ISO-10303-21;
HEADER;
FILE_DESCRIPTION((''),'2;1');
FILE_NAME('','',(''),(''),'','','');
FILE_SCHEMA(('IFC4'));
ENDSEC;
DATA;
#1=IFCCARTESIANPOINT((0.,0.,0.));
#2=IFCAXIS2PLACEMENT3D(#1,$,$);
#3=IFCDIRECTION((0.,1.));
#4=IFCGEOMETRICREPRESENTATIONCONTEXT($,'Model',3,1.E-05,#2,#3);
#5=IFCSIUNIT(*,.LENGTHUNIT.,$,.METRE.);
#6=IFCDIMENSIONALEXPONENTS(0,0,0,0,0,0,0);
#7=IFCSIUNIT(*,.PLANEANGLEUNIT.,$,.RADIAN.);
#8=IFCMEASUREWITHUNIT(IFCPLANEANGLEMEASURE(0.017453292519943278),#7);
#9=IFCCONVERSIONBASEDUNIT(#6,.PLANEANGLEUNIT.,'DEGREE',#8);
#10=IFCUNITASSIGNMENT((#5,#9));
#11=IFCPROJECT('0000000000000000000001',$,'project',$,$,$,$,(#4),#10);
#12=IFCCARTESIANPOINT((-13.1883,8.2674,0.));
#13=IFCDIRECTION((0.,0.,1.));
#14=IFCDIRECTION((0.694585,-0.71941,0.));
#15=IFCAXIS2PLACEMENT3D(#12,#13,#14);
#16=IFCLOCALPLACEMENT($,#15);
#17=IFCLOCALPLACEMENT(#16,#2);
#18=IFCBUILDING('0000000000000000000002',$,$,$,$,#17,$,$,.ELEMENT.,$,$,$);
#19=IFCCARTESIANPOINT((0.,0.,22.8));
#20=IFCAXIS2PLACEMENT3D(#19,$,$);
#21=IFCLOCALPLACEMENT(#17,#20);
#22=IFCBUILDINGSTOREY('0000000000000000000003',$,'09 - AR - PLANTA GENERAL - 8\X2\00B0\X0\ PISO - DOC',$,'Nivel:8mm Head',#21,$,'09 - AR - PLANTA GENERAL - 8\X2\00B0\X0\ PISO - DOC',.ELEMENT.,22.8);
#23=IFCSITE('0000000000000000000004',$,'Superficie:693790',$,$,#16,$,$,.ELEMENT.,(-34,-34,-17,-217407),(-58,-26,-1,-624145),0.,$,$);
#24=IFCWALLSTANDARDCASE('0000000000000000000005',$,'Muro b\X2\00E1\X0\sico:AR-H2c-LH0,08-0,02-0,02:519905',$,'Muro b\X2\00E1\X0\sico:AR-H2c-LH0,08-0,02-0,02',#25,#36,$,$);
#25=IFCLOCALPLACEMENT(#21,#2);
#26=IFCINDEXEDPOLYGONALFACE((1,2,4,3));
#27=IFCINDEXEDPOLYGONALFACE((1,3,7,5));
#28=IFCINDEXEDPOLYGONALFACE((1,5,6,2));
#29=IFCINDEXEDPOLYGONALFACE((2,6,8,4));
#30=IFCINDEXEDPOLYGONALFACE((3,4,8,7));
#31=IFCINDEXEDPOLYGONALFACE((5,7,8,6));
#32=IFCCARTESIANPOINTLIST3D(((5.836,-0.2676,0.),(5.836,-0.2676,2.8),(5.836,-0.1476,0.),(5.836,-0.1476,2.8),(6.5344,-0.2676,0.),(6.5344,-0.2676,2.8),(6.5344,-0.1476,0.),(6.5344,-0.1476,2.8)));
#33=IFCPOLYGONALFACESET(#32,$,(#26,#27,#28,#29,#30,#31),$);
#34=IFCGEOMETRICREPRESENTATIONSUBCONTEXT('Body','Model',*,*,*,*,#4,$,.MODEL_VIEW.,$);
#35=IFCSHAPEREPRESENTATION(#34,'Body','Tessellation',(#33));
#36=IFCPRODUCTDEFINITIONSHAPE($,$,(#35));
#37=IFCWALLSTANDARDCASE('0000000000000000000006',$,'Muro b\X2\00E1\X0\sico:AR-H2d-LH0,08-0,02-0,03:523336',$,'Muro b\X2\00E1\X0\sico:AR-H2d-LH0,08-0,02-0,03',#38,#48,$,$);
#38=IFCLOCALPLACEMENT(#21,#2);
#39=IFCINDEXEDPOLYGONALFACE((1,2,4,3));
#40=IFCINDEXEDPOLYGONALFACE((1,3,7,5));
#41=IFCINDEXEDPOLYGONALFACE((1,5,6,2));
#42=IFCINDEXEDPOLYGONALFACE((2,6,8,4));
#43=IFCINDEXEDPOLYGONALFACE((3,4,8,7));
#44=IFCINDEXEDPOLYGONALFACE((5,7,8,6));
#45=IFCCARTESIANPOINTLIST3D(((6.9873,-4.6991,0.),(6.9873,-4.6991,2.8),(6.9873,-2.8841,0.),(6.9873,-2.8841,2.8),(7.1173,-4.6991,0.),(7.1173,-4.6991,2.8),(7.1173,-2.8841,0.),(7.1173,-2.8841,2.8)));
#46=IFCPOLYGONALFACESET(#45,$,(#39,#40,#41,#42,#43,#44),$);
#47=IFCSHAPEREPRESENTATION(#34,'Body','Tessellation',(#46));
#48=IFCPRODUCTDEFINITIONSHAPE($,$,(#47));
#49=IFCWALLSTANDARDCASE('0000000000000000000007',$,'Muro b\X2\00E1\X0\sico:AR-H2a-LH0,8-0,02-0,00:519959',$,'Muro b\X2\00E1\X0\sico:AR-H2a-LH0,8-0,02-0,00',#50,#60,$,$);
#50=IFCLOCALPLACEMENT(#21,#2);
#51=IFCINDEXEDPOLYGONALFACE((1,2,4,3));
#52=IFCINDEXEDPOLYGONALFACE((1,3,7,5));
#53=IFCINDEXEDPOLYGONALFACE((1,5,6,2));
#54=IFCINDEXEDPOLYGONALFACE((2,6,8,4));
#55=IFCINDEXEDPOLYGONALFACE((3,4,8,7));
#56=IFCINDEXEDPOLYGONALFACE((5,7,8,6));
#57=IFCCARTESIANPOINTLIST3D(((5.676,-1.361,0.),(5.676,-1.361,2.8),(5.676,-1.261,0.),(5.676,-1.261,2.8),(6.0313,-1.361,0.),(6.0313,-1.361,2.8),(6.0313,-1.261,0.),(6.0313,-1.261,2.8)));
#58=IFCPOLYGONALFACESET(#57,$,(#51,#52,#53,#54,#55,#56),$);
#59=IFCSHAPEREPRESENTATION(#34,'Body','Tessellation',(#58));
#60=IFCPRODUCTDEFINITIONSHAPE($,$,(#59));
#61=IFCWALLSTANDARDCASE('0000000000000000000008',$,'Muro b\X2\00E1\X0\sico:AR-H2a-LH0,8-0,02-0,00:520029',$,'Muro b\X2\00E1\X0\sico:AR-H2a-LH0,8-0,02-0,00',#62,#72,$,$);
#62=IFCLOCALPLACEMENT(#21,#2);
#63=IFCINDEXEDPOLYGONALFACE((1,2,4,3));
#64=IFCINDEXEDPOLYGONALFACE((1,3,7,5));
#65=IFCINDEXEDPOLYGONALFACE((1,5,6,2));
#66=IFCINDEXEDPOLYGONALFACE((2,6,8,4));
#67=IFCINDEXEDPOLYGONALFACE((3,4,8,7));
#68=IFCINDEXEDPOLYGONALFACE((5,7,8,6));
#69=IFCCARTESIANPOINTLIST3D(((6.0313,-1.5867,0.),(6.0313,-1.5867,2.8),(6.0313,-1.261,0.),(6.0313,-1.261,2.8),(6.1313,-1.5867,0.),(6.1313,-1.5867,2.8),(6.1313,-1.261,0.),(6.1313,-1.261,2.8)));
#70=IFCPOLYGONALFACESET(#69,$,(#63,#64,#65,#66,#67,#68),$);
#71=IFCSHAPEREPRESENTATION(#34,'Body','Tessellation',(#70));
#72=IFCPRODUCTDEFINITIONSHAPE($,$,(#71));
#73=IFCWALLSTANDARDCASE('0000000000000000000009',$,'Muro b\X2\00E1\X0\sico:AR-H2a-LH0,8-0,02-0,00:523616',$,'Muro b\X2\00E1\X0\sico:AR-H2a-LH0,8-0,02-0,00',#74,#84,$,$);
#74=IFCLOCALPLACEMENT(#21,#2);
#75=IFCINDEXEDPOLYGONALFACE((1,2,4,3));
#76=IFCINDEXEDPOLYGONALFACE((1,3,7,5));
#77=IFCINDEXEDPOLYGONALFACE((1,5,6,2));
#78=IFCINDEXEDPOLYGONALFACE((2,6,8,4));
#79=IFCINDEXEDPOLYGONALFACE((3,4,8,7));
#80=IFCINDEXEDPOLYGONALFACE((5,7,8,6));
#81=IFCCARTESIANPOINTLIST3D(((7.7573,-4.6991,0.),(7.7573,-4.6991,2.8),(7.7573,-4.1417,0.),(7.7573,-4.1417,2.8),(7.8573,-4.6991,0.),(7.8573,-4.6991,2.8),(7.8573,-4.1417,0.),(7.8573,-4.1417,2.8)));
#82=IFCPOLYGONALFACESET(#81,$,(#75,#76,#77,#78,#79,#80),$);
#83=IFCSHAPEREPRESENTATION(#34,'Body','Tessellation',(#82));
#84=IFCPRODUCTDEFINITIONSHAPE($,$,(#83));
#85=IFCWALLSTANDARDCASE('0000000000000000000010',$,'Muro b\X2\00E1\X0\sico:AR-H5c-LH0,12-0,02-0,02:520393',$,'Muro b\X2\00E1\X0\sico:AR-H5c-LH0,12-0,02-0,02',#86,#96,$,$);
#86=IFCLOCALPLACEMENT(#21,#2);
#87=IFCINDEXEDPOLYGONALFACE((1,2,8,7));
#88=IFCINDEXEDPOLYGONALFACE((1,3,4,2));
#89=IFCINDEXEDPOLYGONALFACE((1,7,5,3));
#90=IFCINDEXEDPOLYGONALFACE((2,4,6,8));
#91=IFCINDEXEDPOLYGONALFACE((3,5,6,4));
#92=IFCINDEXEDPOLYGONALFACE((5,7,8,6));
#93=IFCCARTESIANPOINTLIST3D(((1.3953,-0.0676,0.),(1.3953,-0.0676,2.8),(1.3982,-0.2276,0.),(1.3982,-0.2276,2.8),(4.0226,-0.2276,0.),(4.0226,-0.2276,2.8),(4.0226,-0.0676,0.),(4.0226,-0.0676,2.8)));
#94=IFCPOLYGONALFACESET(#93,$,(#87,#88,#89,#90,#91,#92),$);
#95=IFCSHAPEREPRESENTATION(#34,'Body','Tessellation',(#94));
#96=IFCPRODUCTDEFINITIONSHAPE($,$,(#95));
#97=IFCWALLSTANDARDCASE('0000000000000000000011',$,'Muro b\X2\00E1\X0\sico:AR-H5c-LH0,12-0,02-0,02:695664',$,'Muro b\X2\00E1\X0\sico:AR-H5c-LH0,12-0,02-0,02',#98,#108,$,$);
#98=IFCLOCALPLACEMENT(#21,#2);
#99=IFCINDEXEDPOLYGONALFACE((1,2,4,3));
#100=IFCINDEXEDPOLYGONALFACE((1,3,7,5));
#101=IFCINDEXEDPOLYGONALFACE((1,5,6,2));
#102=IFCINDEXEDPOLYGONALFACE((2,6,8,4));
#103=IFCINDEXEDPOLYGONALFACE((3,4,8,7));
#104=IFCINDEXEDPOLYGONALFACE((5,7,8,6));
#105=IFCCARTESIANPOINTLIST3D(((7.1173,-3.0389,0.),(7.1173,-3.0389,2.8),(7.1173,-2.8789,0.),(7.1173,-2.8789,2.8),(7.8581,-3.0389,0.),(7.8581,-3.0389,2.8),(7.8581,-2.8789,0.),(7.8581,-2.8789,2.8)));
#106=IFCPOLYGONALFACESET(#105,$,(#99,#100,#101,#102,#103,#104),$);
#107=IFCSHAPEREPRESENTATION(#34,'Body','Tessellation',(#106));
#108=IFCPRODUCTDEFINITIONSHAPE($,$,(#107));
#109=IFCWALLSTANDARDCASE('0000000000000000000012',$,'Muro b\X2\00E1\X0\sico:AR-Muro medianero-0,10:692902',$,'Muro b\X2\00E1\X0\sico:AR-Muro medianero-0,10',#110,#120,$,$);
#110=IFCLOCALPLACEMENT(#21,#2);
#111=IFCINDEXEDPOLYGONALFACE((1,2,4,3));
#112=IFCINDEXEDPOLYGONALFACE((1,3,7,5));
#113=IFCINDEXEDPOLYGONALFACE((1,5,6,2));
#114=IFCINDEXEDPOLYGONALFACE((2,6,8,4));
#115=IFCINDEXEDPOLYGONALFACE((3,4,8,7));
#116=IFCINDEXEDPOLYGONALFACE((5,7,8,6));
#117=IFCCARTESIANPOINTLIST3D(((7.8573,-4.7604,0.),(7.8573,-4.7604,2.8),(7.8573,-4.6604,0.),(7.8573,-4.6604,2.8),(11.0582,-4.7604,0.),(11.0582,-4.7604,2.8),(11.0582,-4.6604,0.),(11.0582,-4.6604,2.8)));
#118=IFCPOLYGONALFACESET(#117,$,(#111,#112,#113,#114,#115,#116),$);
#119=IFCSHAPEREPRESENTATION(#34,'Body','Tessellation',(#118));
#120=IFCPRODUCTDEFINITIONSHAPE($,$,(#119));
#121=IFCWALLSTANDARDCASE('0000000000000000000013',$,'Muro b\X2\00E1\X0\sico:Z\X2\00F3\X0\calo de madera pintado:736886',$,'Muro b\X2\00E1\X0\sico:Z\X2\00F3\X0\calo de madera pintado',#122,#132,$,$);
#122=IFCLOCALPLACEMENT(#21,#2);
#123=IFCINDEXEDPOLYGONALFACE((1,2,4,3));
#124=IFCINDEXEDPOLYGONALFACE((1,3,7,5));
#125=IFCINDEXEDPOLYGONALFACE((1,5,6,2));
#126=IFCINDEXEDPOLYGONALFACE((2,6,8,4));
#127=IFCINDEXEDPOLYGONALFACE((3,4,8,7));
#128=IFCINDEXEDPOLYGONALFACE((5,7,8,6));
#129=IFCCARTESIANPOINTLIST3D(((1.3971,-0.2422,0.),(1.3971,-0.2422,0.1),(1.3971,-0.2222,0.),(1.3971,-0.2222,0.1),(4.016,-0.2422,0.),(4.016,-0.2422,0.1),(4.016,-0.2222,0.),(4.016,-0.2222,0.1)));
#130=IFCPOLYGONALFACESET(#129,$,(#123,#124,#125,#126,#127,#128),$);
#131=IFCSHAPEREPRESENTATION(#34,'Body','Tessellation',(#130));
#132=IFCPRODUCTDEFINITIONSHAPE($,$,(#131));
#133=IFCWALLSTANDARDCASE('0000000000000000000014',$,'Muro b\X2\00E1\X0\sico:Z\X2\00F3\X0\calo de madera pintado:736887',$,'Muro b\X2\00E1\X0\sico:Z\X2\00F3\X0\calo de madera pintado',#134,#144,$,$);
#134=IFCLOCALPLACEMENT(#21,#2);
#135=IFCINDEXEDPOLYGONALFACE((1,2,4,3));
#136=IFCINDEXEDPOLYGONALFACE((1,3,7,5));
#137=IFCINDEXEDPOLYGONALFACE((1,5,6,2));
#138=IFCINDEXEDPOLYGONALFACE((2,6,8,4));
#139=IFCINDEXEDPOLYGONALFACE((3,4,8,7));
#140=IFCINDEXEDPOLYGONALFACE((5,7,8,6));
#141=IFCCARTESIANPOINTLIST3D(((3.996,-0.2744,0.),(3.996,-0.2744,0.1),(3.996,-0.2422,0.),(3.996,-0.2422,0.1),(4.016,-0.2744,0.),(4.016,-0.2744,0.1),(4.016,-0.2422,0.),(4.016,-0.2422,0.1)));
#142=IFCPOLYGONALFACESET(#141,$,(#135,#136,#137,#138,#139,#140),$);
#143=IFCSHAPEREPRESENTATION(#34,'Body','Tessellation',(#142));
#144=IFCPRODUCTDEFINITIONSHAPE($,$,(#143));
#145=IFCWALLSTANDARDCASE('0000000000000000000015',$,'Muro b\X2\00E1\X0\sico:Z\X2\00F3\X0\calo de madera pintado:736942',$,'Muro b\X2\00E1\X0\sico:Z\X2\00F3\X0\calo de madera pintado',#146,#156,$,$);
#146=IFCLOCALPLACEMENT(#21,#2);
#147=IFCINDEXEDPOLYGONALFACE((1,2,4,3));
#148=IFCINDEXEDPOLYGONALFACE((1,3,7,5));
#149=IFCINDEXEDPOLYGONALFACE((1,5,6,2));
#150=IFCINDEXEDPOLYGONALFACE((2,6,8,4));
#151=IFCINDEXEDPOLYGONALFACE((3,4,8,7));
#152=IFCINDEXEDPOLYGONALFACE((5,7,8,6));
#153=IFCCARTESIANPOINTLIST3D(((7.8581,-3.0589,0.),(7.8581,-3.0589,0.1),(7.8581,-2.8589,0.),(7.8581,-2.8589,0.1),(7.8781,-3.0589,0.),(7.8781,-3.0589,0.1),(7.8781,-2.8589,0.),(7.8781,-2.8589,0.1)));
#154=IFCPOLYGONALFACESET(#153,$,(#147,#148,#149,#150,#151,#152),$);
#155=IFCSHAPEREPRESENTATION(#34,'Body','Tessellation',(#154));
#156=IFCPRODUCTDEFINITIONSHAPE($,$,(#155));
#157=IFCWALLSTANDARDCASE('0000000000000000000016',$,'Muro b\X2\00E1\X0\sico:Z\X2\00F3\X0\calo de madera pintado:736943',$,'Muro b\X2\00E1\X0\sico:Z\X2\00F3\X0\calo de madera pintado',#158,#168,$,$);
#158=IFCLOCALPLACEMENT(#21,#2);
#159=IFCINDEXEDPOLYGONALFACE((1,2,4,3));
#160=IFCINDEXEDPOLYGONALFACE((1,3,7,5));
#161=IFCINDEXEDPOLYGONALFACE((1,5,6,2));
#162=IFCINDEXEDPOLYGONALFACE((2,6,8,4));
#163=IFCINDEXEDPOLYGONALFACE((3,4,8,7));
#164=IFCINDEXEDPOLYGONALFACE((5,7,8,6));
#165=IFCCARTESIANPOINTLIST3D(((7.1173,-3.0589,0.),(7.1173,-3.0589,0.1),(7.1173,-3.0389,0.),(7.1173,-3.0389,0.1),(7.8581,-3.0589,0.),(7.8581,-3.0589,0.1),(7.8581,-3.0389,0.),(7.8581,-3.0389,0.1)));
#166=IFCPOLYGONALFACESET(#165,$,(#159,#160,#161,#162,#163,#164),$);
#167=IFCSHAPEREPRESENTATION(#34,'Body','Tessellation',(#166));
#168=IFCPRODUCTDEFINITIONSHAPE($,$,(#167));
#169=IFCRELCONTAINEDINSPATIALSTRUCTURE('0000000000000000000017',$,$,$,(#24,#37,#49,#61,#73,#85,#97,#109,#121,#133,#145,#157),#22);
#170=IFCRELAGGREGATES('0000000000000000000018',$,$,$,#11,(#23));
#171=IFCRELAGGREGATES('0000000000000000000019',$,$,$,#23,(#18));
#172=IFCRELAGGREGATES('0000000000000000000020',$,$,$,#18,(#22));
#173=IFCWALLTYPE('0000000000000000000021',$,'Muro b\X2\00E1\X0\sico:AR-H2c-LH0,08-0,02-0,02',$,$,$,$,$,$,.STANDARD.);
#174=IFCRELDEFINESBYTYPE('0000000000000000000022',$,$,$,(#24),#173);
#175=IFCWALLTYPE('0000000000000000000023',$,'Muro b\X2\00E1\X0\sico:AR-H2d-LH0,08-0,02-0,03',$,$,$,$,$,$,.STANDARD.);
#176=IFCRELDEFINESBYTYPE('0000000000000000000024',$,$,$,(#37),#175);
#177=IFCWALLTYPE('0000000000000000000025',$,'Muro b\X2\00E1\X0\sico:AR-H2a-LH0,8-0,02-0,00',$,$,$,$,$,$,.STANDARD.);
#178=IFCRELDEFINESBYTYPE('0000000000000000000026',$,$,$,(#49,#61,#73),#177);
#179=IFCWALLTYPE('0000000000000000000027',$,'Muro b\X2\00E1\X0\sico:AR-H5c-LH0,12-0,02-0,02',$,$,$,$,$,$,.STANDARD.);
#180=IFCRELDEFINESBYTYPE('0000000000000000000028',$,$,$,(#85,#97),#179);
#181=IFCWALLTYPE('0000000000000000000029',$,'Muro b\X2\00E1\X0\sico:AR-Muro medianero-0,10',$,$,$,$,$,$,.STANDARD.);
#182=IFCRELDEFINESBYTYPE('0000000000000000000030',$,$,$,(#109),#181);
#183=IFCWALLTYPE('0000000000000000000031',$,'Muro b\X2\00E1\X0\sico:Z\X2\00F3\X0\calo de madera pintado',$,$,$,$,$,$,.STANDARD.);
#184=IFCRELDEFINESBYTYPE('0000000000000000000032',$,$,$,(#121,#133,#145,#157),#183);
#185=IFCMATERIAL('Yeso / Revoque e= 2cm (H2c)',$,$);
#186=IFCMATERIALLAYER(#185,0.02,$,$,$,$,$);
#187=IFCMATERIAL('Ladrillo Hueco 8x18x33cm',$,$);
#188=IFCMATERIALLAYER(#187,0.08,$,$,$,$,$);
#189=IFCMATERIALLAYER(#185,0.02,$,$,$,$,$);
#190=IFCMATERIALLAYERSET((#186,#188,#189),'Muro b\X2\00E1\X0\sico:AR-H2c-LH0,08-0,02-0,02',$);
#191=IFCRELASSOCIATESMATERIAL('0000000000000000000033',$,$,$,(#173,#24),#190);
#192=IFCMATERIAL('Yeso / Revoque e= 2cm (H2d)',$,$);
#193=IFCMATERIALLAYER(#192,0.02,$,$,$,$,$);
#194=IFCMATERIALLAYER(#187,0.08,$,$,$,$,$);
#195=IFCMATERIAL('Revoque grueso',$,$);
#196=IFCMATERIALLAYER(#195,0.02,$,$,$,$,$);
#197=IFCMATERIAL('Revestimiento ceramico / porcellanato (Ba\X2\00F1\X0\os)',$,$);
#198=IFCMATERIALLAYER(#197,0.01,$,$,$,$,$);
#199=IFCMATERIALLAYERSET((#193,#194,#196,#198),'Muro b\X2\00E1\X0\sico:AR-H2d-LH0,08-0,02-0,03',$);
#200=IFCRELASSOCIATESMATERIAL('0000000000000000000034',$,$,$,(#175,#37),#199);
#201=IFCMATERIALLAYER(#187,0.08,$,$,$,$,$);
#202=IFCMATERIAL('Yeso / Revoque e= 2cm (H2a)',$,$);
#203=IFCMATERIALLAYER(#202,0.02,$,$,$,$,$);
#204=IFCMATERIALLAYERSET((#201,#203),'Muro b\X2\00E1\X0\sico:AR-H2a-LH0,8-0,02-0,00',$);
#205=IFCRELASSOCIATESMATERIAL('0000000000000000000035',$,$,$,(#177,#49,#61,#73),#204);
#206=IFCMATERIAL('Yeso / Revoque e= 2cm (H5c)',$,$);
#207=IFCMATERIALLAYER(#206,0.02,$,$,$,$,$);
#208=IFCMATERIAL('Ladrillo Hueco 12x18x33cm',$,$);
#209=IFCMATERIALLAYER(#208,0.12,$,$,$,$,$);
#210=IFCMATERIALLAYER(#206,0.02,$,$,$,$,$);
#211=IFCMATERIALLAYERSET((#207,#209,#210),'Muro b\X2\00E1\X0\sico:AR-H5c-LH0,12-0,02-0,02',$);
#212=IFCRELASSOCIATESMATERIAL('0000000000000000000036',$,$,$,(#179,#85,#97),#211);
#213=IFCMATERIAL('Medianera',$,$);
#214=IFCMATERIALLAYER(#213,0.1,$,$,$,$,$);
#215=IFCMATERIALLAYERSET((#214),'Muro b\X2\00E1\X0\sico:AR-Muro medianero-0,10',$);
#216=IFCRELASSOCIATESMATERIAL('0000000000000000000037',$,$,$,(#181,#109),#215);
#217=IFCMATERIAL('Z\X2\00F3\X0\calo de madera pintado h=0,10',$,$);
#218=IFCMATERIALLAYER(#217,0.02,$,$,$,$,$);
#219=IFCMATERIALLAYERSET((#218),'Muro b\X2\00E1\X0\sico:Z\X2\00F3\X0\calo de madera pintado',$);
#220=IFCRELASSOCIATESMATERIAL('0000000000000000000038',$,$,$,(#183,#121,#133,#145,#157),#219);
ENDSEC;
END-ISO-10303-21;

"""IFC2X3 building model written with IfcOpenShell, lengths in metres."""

from ifc_helpers import new_model, entity, si_unit, converted_unit, direction, frame, frame_2d, origin, place, context, subcontext, project, spatial, polyline, rectangle, outline, extrude, material, layer, layer_set, layer_usage, type_object, element, save


model = new_model("IFC2X3")

# Units and contexts
model_context = context("Model", 3, precision=1e-05, world=origin(), true_north=direction((0.0, 1.0)))
body_context = subcontext(model_context, "Body", "Model", "MODEL_VIEW")
ifc_project = project(units=[si_unit("LENGTHUNIT", "METRE"), converted_unit("PLANEANGLEUNIT", "DEGREE", entity("IfcPlaneAngleMeasure", 0.017453292519943278), si_unit("PLANEANGLEUNIT", "RADIAN"), dimensions=[0, 0, 0, 0, 0, 0, 0])], contexts=[model_context])

# Site, building, storey
site_placement = place(None, frame((-13.1883, 8.2674, 0.0), z_axis=(0.0, 0.0, 1.0), x_axis=(0.694585, -0.71941, 0.0)))
site = spatial("IfcSite", under=ifc_project, at=site_placement, Name="Superficie:693790", CompositionType="ELEMENT", RefLatitude=(-34, -34, -17, -217407), RefLongitude=(-58, -26, -1, -624145), RefElevation=0.0)
building_placement = place(site_placement, origin())
building = spatial("IfcBuilding", under=site, at=building_placement, CompositionType="ELEMENT")
storey_placement = place(building_placement, frame((0.0, 0.0, 22.8)))
storey = spatial("IfcBuildingStorey", under=building, at=storey_placement, Name="09 - AR - PLANTA GENERAL - 8° PISO - DOC", ObjectType="Nivel:8mm Head", LongName="09 - AR - PLANTA GENERAL - 8° PISO - DOC", CompositionType="ELEMENT", Elevation=22.8)

# Walls
ifc_material_1 = material(Name="Yeso / Revoque e= 2cm (H2c)")
ifc_layer_1 = layer(ifc_material_1, 0.02)
ifc_material_2 = material(Name="Ladrillo Hueco 8x18x33cm")
ifc_layer_2 = layer(ifc_material_2, 0.08)
ifc_layer_3 = layer(ifc_material_1, 0.02)
ifc_layer_set_1 = layer_set([ifc_layer_1, ifc_layer_2, ifc_layer_3], Name="Muro básico:AR-H2c-LH0,08-0,02-0,02")
ifc_layer_usage_1 = layer_usage(ifc_layer_set_1, "AXIS2", "NEGATIVE", 0.06)
wall_type_1 = type_object("IfcWallType", Name="Muro básico:AR-H2c-LH0,08-0,02-0,02", PredefinedType="STANDARD", material=ifc_layer_set_1)
wall_1_placement = place(storey_placement, frame((5.836, -0.2076, 0.0)))
element("IfcWallStandardCase", 1, at=wall_1_placement, inside=storey, type_object=wall_type_1, material=ifc_layer_usage_1, Name="Muro básico:AR-H2c-LH0,08-0,02-0,02:519905", ObjectType="Muro básico:AR-H2c-LH0,08-0,02-0,02", context=body_context, shape_type="SweptSolid", body=[
    extrude(rectangle(XDim=0.6984, YDim=0.12, at=frame_2d((0.3492, 0.0), x_axis=(-1.0, 0.0))), origin(), (0.0, 0.0, 1.0), 2.8),
])
ifc_material_3 = material(Name="Yeso / Revoque e= 2cm (H2d)")
ifc_layer_4 = layer(ifc_material_3, 0.02)
ifc_layer_5 = layer(ifc_material_2, 0.08)
ifc_material_4 = material(Name="Revoque grueso")
ifc_layer_6 = layer(ifc_material_4, 0.02)
ifc_material_5 = material(Name="Revestimiento ceramico / porcellanato (Baños)")
ifc_layer_7 = layer(ifc_material_5, 0.01)
ifc_layer_set_2 = layer_set([ifc_layer_4, ifc_layer_5, ifc_layer_6, ifc_layer_7], Name="Muro básico:AR-H2d-LH0,08-0,02-0,03")
ifc_layer_usage_2 = layer_usage(ifc_layer_set_2, "AXIS2", "NEGATIVE", 0.065)
wall_type_2 = type_object("IfcWallType", Name="Muro básico:AR-H2d-LH0,08-0,02-0,03", PredefinedType="STANDARD", material=ifc_layer_set_2)
wall_2_placement = place(storey_placement, frame((7.0523, -2.8841, 0.0), z_axis=(0.0, 0.0, 1.0), x_axis=(0.0, -1.0, 0.0)))
element("IfcWallStandardCase", 2, at=wall_2_placement, inside=storey, type_object=wall_type_2, material=ifc_layer_usage_2, Name="Muro básico:AR-H2d-LH0,08-0,02-0,03:523336", ObjectType="Muro básico:AR-H2d-LH0,08-0,02-0,03", context=body_context, shape_type="SweptSolid", body=[
    extrude(rectangle(XDim=1.815, YDim=0.13, at=frame_2d((0.9075, 0.0), x_axis=(-1.0, 0.0))), origin(), (0.0, 0.0, 1.0), 2.8),
])
ifc_layer_8 = layer(ifc_material_2, 0.08)
ifc_material_6 = material(Name="Yeso / Revoque e= 2cm (H2a)")
ifc_layer_9 = layer(ifc_material_6, 0.02)
ifc_layer_set_3 = layer_set([ifc_layer_8, ifc_layer_9], Name="Muro básico:AR-H2a-LH0,8-0,02-0,00")
ifc_layer_usage_3 = layer_usage(ifc_layer_set_3, "AXIS2", "POSITIVE", -0.05)
wall_type_3 = type_object("IfcWallType", Name="Muro básico:AR-H2a-LH0,8-0,02-0,00", PredefinedType="STANDARD", material=ifc_layer_set_3)
wall_3_placement = place(storey_placement, frame((5.676, -1.311, 0.0)))
element("IfcWallStandardCase", 3, at=wall_3_placement, inside=storey, type_object=wall_type_3, material=ifc_layer_usage_3, Name="Muro básico:AR-H2a-LH0,8-0,02-0,00:519959", ObjectType="Muro básico:AR-H2a-LH0,8-0,02-0,00", context=body_context, shape_type="SweptSolid", body=[
    extrude(rectangle(XDim=0.3553, YDim=0.1, at=frame_2d((0.1776, 0.0), x_axis=(-1.0, 0.0))), origin(), (0.0, 0.0, 1.0), 2.8),
])
ifc_layer_usage_4 = layer_usage(ifc_layer_set_3, "AXIS2", "POSITIVE", -0.05)
wall_4_placement = place(storey_placement, frame((6.0813, -1.261, 0.0), z_axis=(0.0, 0.0, 1.0), x_axis=(0.0, -1.0, 0.0)))
element("IfcWallStandardCase", 4, at=wall_4_placement, inside=storey, type_object=wall_type_3, material=ifc_layer_usage_4, Name="Muro básico:AR-H2a-LH0,8-0,02-0,00:520029", ObjectType="Muro básico:AR-H2a-LH0,8-0,02-0,00", context=body_context, shape_type="SweptSolid", body=[
    extrude(rectangle(XDim=0.3257, YDim=0.1, at=frame_2d((0.1629, 0.0), x_axis=(-1.0, 0.0))), origin(), (0.0, 0.0, 1.0), 2.8),
])
ifc_layer_usage_5 = layer_usage(ifc_layer_set_3, "AXIS2", "POSITIVE", -0.05)
wall_5_placement = place(storey_placement, frame((7.8073, -4.1417, 0.0), z_axis=(0.0, 0.0, 1.0), x_axis=(0.0, -1.0, 0.0)))
element("IfcWallStandardCase", 5, at=wall_5_placement, inside=storey, type_object=wall_type_3, material=ifc_layer_usage_5, Name="Muro básico:AR-H2a-LH0,8-0,02-0,00:523616", ObjectType="Muro básico:AR-H2a-LH0,8-0,02-0,00", context=body_context, shape_type="SweptSolid", body=[
    extrude(rectangle(XDim=0.5574, YDim=0.1, at=frame_2d((0.2787, 0.0), x_axis=(-1.0, 0.0))), origin(), (0.0, 0.0, 1.0), 2.8),
])
ifc_material_7 = material(Name="Yeso / Revoque e= 2cm (H5c)")
ifc_layer_10 = layer(ifc_material_7, 0.02)
ifc_material_8 = material(Name="Ladrillo Hueco 12x18x33cm")
ifc_layer_11 = layer(ifc_material_8, 0.12)
ifc_layer_12 = layer(ifc_material_7, 0.02)
ifc_layer_set_4 = layer_set([ifc_layer_10, ifc_layer_11, ifc_layer_12], Name="Muro básico:AR-H5c-LH0,12-0,02-0,02")
ifc_layer_usage_6 = layer_usage(ifc_layer_set_4, "AXIS2", "POSITIVE", -0.08)
wall_type_4 = type_object("IfcWallType", Name="Muro básico:AR-H5c-LH0,12-0,02-0,02", PredefinedType="STANDARD", material=ifc_layer_set_4)
wall_6_placement = place(storey_placement, frame((4.0226, -0.1476, 0.0), z_axis=(0.0, 0.0, 1.0), x_axis=(-1.0, 0.0, 0.0)))
element("IfcWallStandardCase", 6, at=wall_6_placement, inside=storey, type_object=wall_type_4, material=ifc_layer_usage_6, Name="Muro básico:AR-H5c-LH0,12-0,02-0,02:520393", ObjectType="Muro básico:AR-H5c-LH0,12-0,02-0,02", context=body_context, shape_type="SweptSolid", body=[
    extrude(outline(polyline([(2.6273, -0.08), (2.6245, 0.08), (0.0, 0.08), (0.0, -0.08), (2.6273, -0.08)])), origin(), (0.0, 0.0, 1.0), 2.8),
])
ifc_layer_usage_7 = layer_usage(ifc_layer_set_4, "AXIS2", "NEGATIVE", 0.08)
wall_7_placement = place(storey_placement, frame((7.1173, -2.9589, 0.0)))
element("IfcWallStandardCase", 7, at=wall_7_placement, inside=storey, type_object=wall_type_4, material=ifc_layer_usage_7, Name="Muro básico:AR-H5c-LH0,12-0,02-0,02:695664", ObjectType="Muro básico:AR-H5c-LH0,12-0,02-0,02", context=body_context, shape_type="SweptSolid", body=[
    extrude(rectangle(XDim=0.7407, YDim=0.16, at=frame_2d((0.3704, 0.0), x_axis=(-1.0, 0.0))), origin(), (0.0, 0.0, 1.0), 2.8),
])
ifc_material_9 = material(Name="Medianera")
ifc_layer_13 = layer(ifc_material_9, 0.1)
ifc_layer_set_5 = layer_set([ifc_layer_13], Name="Muro básico:AR-Muro medianero-0,10")
ifc_layer_usage_8 = layer_usage(ifc_layer_set_5, "AXIS2", "NEGATIVE", 0.05)
wall_type_5 = type_object("IfcWallType", Name="Muro básico:AR-Muro medianero-0,10", PredefinedType="STANDARD", material=ifc_layer_set_5)
wall_8_placement = place(storey_placement, frame((7.8573, -4.7104, 0.0)))
element("IfcWallStandardCase", 8, at=wall_8_placement, inside=storey, type_object=wall_type_5, material=ifc_layer_usage_8, Name="Muro básico:AR-Muro medianero-0,10:692902", ObjectType="Muro básico:AR-Muro medianero-0,10", context=body_context, shape_type="SweptSolid", body=[
    extrude(rectangle(XDim=3.2009, YDim=0.1, at=frame_2d((1.6004, 0.0), x_axis=(-1.0, 0.0))), origin(), (0.0, 0.0, 1.0), 2.8),
])
ifc_material_10 = material(Name="Zócalo de madera pintado h=0,10")
ifc_layer_14 = layer(ifc_material_10, 0.02)
ifc_layer_set_6 = layer_set([ifc_layer_14], Name="Muro básico:Zócalo de madera pintado")
ifc_layer_usage_9 = layer_usage(ifc_layer_set_6, "AXIS2", "NEGATIVE", 0.01)
wall_type_6 = type_object("IfcWallType", Name="Muro básico:Zócalo de madera pintado", PredefinedType="STANDARD", material=ifc_layer_set_6)
wall_9_placement = place(storey_placement, frame((4.016, -0.2322, 0.0), z_axis=(0.0, 0.0, 1.0), x_axis=(-1.0, 0.0, 0.0)))
element("IfcWallStandardCase", 9, at=wall_9_placement, inside=storey, type_object=wall_type_6, material=ifc_layer_usage_9, Name="Muro básico:Zócalo de madera pintado:736886", ObjectType="Muro básico:Zócalo de madera pintado", context=body_context, shape_type="SweptSolid", body=[
    extrude(rectangle(XDim=2.6189, YDim=0.02, at=frame_2d((1.3095, 0.0), x_axis=(-1.0, 0.0))), origin(), (0.0, 0.0, 1.0), 0.1),
])
ifc_layer_usage_10 = layer_usage(ifc_layer_set_6, "AXIS2", "NEGATIVE", 0.01)
wall_10_placement = place(storey_placement, frame((4.006, -0.2744, 0.0), z_axis=(0.0, 0.0, 1.0), x_axis=(0.0, 1.0, 0.0)))
element("IfcWallStandardCase", 10, at=wall_10_placement, inside=storey, type_object=wall_type_6, material=ifc_layer_usage_10, Name="Muro básico:Zócalo de madera pintado:736887", ObjectType="Muro básico:Zócalo de madera pintado", context=body_context, shape_type="SweptSolid", body=[
    extrude(rectangle(XDim=0.0323, YDim=0.02, at=frame_2d((0.0161, 0.0), x_axis=(-1.0, 0.0))), origin(), (0.0, 0.0, 1.0), 0.1),
])
ifc_layer_usage_11 = layer_usage(ifc_layer_set_6, "AXIS2", "NEGATIVE", 0.01)
wall_11_placement = place(storey_placement, frame((7.8681, -3.0589, 0.0), z_axis=(0.0, 0.0, 1.0), x_axis=(0.0, 1.0, 0.0)))
element("IfcWallStandardCase", 11, at=wall_11_placement, inside=storey, type_object=wall_type_6, material=ifc_layer_usage_11, Name="Muro básico:Zócalo de madera pintado:736942", ObjectType="Muro básico:Zócalo de madera pintado", context=body_context, shape_type="SweptSolid", body=[
    extrude(rectangle(XDim=0.2, YDim=0.02, at=frame_2d((0.1, 0.0), x_axis=(-1.0, 0.0))), origin(), (0.0, 0.0, 1.0), 0.1),
])
ifc_layer_usage_12 = layer_usage(ifc_layer_set_6, "AXIS2", "NEGATIVE", 0.01)
wall_12_placement = place(storey_placement, frame((7.1173, -3.0489, 0.0)))
element("IfcWallStandardCase", 12, at=wall_12_placement, inside=storey, type_object=wall_type_6, material=ifc_layer_usage_12, Name="Muro básico:Zócalo de madera pintado:736943", ObjectType="Muro básico:Zócalo de madera pintado", context=body_context, shape_type="SweptSolid", body=[
    extrude(rectangle(XDim=0.7407, YDim=0.02, at=frame_2d((0.3704, 0.0), x_axis=(-1.0, 0.0))), origin(), (0.0, 0.0, 1.0), 0.1),
])

save(model, "model.ifc")
